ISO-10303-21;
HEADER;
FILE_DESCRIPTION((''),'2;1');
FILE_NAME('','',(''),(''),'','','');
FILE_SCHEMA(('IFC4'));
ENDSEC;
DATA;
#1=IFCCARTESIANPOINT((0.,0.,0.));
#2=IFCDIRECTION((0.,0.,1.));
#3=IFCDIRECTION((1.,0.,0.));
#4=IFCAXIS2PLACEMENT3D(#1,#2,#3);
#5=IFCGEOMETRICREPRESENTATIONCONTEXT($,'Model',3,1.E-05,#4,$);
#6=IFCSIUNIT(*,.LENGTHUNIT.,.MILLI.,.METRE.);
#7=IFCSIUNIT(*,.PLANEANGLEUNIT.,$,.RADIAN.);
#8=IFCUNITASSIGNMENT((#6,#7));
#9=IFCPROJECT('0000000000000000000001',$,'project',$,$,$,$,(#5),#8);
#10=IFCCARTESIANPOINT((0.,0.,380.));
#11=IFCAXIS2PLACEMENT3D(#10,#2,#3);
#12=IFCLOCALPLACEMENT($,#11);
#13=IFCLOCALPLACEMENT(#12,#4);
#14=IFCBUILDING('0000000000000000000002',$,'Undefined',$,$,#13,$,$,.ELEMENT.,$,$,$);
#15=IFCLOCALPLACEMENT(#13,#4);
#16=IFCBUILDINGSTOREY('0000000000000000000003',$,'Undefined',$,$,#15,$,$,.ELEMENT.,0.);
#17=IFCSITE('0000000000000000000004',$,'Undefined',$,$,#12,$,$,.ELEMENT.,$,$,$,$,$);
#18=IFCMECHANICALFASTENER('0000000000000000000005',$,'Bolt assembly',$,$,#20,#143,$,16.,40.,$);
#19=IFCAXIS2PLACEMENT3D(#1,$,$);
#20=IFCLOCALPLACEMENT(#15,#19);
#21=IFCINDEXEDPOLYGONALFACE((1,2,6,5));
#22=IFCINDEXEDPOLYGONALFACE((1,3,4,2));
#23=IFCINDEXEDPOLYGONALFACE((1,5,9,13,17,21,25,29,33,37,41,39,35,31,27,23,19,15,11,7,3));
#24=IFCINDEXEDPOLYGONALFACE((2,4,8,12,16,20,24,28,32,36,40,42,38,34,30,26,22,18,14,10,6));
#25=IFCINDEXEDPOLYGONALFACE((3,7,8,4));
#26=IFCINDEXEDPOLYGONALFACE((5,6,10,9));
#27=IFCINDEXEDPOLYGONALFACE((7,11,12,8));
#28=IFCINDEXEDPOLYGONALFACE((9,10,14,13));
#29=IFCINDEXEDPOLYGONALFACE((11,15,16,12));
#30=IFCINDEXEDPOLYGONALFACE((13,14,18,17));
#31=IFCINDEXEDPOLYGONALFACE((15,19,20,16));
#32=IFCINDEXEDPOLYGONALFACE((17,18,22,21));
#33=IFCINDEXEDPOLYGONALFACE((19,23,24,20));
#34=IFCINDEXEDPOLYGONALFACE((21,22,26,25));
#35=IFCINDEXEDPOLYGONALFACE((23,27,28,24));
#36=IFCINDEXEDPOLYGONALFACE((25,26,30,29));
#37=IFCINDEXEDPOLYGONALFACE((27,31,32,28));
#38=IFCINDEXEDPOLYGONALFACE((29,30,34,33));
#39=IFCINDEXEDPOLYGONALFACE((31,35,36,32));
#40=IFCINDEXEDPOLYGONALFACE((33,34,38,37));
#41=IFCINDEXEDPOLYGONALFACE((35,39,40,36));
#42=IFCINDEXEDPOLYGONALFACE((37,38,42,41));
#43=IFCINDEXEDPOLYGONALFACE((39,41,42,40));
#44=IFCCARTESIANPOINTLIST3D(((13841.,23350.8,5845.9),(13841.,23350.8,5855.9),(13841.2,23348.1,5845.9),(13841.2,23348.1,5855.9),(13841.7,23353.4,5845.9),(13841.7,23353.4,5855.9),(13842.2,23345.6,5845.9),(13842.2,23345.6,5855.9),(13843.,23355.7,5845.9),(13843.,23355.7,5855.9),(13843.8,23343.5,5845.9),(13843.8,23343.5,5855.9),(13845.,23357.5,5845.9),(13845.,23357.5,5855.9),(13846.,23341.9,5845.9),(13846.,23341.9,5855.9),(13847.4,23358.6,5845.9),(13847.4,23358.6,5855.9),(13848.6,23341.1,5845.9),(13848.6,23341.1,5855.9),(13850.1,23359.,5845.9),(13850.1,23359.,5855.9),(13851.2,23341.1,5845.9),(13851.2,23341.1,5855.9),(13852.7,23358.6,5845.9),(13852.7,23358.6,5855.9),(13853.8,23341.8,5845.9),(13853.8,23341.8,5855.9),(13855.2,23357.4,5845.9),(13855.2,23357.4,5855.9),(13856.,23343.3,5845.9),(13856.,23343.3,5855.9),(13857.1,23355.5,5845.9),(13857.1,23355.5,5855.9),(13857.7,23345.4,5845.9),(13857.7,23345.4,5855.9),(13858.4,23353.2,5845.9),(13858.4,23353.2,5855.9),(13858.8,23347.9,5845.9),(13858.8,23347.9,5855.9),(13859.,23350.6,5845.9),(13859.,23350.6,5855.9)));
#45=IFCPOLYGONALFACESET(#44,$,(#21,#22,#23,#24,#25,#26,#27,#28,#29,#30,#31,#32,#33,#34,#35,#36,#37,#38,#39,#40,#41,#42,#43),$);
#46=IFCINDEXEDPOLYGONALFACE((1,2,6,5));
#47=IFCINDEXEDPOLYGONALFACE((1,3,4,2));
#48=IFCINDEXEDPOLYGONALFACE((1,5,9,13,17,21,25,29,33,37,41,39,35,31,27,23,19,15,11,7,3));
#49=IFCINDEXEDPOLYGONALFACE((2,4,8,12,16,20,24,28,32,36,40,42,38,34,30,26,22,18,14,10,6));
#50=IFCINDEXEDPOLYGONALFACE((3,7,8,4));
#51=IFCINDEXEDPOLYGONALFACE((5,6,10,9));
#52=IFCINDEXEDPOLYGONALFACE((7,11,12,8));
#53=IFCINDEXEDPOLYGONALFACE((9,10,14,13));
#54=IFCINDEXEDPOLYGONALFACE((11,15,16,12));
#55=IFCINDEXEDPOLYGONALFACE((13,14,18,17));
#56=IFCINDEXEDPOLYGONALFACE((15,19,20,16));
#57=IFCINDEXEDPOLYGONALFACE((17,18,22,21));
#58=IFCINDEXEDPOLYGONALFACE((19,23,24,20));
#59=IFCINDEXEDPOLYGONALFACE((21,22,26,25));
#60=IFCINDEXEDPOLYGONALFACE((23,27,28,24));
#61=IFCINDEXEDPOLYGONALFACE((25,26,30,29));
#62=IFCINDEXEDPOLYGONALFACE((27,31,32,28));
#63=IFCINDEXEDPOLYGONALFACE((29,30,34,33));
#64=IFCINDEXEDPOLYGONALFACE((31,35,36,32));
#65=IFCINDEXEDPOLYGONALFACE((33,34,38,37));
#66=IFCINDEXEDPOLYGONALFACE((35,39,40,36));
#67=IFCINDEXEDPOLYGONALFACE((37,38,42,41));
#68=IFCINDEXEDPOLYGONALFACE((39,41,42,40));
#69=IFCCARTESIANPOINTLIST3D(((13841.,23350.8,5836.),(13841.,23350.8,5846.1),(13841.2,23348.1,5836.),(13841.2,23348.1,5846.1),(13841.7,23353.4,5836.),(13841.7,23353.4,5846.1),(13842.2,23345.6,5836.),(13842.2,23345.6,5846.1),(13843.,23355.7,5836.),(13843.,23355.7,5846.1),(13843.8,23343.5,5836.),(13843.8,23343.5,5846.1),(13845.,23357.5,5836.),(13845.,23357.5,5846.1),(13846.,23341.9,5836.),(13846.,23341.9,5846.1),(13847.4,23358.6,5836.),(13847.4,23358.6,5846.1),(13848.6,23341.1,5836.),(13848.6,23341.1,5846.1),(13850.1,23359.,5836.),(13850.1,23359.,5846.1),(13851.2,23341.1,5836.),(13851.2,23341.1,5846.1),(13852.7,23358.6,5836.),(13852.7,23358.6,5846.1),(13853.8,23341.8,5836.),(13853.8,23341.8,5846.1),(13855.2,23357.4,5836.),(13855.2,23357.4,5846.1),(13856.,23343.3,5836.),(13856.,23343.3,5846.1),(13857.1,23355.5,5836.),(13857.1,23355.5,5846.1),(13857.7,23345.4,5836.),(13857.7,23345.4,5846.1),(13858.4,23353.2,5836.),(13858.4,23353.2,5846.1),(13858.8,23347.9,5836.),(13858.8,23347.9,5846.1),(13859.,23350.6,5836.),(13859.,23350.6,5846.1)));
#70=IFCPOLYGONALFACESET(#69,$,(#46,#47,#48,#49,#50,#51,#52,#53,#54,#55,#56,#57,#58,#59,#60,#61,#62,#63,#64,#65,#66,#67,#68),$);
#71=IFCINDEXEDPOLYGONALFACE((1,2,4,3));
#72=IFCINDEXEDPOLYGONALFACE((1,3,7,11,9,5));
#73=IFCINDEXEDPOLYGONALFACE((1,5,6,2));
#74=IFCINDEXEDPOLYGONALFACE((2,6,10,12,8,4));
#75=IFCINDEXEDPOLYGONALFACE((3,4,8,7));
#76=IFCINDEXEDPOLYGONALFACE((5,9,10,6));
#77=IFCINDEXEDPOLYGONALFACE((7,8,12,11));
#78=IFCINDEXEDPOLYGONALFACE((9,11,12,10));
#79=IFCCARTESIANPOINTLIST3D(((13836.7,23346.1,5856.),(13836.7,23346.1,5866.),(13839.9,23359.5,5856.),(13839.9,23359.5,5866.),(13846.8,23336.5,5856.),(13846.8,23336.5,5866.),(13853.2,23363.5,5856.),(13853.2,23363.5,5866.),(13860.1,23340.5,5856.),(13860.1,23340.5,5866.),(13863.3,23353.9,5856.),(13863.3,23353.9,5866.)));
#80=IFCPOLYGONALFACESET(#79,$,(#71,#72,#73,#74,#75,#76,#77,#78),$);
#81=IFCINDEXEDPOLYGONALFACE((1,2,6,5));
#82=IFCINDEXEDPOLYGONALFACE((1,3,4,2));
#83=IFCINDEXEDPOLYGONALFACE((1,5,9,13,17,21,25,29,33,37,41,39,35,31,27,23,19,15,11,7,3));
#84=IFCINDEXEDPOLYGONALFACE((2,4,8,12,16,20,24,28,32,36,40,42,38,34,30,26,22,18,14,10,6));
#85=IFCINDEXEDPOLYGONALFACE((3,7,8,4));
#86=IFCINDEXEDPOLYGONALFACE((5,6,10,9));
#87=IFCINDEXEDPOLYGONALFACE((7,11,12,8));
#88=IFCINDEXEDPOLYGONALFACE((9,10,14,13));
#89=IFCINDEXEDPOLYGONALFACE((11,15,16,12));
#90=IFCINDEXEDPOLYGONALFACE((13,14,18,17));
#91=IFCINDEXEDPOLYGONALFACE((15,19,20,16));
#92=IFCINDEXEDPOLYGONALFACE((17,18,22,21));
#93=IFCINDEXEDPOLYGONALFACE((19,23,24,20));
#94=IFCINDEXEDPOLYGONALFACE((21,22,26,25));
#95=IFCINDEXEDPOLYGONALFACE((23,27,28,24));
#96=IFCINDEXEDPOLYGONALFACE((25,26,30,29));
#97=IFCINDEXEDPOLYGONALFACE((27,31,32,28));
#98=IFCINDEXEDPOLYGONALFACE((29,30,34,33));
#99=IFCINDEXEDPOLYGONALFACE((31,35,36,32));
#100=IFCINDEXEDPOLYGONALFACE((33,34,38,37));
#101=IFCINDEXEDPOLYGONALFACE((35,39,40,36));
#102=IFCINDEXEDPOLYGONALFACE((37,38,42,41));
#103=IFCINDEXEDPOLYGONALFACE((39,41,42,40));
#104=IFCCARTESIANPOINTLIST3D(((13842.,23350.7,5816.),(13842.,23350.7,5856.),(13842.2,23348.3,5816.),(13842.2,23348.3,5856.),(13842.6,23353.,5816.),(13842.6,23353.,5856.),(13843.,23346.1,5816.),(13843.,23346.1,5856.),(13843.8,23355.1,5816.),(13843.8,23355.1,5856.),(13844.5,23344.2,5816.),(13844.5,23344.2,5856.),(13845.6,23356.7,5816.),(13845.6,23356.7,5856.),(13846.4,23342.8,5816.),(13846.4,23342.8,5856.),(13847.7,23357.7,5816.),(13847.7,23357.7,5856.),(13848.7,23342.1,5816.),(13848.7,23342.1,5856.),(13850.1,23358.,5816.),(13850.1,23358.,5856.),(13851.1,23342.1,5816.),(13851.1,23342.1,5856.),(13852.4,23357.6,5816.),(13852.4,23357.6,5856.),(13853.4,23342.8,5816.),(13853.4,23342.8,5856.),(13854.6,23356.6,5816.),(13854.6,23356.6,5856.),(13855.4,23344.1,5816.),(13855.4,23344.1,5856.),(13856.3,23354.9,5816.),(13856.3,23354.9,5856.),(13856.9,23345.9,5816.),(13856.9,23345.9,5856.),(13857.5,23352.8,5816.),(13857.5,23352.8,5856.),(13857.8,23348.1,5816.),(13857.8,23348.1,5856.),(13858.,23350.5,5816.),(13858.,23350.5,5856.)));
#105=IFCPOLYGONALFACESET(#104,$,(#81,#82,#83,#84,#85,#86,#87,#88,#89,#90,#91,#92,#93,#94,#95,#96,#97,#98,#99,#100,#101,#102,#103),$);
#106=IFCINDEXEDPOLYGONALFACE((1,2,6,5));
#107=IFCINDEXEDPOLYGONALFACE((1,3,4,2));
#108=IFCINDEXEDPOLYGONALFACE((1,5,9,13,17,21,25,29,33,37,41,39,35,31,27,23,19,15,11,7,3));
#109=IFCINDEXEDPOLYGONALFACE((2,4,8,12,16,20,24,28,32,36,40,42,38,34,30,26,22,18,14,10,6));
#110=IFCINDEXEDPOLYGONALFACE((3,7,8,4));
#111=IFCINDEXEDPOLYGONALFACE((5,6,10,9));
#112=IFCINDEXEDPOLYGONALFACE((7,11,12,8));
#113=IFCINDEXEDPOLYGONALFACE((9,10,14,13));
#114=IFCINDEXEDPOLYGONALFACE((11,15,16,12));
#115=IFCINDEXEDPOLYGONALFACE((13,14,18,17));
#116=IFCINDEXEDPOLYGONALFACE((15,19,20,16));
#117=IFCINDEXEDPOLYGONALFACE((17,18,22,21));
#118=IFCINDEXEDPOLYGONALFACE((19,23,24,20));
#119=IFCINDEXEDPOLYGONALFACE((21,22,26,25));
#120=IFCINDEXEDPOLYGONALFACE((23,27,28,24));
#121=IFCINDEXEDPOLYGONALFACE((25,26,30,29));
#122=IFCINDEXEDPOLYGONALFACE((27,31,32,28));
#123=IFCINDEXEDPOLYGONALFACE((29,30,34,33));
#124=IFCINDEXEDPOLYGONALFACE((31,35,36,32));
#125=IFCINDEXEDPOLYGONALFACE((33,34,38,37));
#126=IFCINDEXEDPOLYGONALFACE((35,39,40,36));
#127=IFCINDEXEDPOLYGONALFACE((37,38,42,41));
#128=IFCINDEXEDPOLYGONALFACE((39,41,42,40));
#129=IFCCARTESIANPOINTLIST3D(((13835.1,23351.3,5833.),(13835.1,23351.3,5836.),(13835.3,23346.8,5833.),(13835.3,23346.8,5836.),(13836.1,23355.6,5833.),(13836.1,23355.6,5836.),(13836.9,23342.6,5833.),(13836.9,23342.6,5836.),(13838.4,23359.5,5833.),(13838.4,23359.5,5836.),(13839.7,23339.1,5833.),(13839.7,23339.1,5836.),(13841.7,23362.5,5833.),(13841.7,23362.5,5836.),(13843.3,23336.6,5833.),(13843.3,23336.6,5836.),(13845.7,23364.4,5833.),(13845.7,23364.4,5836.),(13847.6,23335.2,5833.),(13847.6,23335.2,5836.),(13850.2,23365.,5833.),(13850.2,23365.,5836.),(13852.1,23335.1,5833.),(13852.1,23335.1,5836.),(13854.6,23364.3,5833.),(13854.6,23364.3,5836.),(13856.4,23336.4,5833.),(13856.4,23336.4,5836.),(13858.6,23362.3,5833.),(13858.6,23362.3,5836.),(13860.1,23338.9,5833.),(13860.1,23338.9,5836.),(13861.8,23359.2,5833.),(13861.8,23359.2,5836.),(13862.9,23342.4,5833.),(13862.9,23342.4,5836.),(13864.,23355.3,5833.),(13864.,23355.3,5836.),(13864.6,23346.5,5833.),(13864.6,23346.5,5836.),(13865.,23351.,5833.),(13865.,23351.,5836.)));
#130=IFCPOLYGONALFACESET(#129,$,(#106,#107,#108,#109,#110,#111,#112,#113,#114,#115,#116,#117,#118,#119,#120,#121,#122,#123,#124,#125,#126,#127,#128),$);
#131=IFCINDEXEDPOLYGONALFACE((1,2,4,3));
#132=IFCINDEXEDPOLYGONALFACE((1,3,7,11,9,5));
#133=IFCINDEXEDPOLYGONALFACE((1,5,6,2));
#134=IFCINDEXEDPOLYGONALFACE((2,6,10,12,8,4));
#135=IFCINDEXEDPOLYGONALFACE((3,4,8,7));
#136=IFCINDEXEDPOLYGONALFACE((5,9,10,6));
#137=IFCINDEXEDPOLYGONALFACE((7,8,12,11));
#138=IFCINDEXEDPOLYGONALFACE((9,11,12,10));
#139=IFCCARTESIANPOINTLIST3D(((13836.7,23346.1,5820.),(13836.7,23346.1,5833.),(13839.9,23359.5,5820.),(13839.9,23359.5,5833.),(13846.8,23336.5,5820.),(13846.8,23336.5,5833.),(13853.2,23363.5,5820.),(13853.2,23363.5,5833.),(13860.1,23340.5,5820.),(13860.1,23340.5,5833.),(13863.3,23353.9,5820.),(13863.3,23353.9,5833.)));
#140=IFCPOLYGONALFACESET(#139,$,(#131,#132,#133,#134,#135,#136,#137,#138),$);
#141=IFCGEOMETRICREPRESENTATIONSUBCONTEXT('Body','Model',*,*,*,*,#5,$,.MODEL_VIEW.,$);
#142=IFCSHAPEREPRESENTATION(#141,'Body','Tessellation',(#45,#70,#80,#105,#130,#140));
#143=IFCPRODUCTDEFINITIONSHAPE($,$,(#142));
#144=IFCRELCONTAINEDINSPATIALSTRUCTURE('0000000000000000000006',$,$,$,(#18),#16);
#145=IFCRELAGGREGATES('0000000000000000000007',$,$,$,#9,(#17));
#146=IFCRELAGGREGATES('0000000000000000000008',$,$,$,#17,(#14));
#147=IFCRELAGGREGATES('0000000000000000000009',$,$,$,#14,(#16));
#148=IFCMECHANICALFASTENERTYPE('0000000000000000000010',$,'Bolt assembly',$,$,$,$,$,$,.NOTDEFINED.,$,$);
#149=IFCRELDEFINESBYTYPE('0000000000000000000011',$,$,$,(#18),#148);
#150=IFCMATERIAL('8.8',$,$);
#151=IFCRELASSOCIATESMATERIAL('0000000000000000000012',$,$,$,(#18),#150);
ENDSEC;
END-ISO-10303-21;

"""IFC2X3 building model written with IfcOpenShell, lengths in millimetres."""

from ifc_helpers import new_model, si_unit, frame, origin_with_axes, origin_2d_with_axis, place, context, subcontext, project, spatial, polyline, circle, outline, extrude, source, transform, mapped, material, type_object, element, save


model = new_model("IFC2X3")

# Units and contexts
model_context = context("Model", 3, precision=1e-05, world=origin_with_axes())
body_context = subcontext(model_context, "Body", "Model", "MODEL_VIEW")
ifc_project = project(units=[si_unit("LENGTHUNIT", "METRE", prefix="MILLI"), si_unit("PLANEANGLEUNIT", "RADIAN")], contexts=[model_context])

# Site, building, storey
site_placement = place(None, frame((0.0, 0.0, 380.0), z_axis=(0.0, 0.0, 1.0), x_axis=(1.0, 0.0, 0.0)))
site = spatial("IfcSite", under=ifc_project, at=site_placement, Name="Undefined", CompositionType="ELEMENT")
building_placement = place(site_placement, origin_with_axes())
building = spatial("IfcBuilding", under=site, at=building_placement, Name="Undefined", CompositionType="ELEMENT")
storey_placement = place(building_placement, origin_with_axes())
storey = spatial("IfcBuildingStorey", under=building, at=storey_placement, Name="Undefined", CompositionType="ELEMENT", Elevation=0.0)

# Mechanical fastener
ifc_material_1 = material(Name="8.8")
mechanical_fastener_type = type_object("IfcMechanicalFastenerType", Name="Bolt assembly")
shared_shape_1 = source(origin_with_axes(), body_context, "Body", "SweptSolid", [
    extrude(circle(Radius=9.0, at=origin_2d_with_axis()), frame((0.0, -4.9, 0.0), z_axis=(0.0, 1.0, 0.0), x_axis=(1.0, 0.0, 0.0)), (0.0, 0.0, 1.0), 10.0),
    extrude(circle(Radius=9.0, at=origin_2d_with_axis()), frame((0.0, 4.9, 0.0), z_axis=(0.0, 1.0, 0.0), x_axis=(1.0, 0.0, 0.0)), (0.0, 0.0, 1.0), 10.1),
    extrude(outline(polyline([(12.0, -6.9), (12.0, 6.9), (0.0, 13.9), (-12.0, 6.9), (-12.0, -6.9), (0.0, -13.9), (12.0, -6.9)])), frame((0.0, -15.0, 0.0), z_axis=(0.0, 1.0, 0.0), x_axis=(1.0, 0.0, 0.0)), (0.0, 0.0, 1.0), 10.0),
    extrude(circle(Radius=8.0, at=origin_2d_with_axis()), frame((0.0, -5.0, 0.0), z_axis=(0.0, 1.0, 0.0), x_axis=(1.0, 0.0, 0.0)), (0.0, 0.0, 1.0), 40.0),
    extrude(circle(Radius=15.0, at=origin_2d_with_axis()), frame((0.0, 15.0, 0.0), z_axis=(0.0, 1.0, 0.0), x_axis=(1.0, 0.0, 0.0)), (0.0, 0.0, 1.0), 3.0),
    extrude(outline(polyline([(12.0, -6.9), (12.0, 6.9), (0.0, 13.9), (-12.0, 6.9), (-12.0, -6.9), (0.0, -13.9), (12.0, -6.9)])), frame((0.0, 18.0, 0.0), z_axis=(0.0, 1.0, 0.0), x_axis=(1.0, 0.0, 0.0)), (0.0, 0.0, 1.0), 13.0),
])
mechanical_fastener_1_placement = place(storey_placement, frame((13850.0, 23350.0, 5851.0), z_axis=(0.725464, -0.68826, 0.0), x_axis=(-0.68826, -0.725464, 0.0)))
element("IfcMechanicalFastener", 1, at=mechanical_fastener_1_placement, inside=storey, type_object=mechanical_fastener_type, material=ifc_material_1, Name="Bolt assembly", NominalDiameter=16.0, NominalLength=40.0, context=body_context, shape_type="MappedRepresentation", body=[
    mapped(shared_shape_1, transform((0.0, 0.0, 0.0))),
])

save(model, "model.ifc")
